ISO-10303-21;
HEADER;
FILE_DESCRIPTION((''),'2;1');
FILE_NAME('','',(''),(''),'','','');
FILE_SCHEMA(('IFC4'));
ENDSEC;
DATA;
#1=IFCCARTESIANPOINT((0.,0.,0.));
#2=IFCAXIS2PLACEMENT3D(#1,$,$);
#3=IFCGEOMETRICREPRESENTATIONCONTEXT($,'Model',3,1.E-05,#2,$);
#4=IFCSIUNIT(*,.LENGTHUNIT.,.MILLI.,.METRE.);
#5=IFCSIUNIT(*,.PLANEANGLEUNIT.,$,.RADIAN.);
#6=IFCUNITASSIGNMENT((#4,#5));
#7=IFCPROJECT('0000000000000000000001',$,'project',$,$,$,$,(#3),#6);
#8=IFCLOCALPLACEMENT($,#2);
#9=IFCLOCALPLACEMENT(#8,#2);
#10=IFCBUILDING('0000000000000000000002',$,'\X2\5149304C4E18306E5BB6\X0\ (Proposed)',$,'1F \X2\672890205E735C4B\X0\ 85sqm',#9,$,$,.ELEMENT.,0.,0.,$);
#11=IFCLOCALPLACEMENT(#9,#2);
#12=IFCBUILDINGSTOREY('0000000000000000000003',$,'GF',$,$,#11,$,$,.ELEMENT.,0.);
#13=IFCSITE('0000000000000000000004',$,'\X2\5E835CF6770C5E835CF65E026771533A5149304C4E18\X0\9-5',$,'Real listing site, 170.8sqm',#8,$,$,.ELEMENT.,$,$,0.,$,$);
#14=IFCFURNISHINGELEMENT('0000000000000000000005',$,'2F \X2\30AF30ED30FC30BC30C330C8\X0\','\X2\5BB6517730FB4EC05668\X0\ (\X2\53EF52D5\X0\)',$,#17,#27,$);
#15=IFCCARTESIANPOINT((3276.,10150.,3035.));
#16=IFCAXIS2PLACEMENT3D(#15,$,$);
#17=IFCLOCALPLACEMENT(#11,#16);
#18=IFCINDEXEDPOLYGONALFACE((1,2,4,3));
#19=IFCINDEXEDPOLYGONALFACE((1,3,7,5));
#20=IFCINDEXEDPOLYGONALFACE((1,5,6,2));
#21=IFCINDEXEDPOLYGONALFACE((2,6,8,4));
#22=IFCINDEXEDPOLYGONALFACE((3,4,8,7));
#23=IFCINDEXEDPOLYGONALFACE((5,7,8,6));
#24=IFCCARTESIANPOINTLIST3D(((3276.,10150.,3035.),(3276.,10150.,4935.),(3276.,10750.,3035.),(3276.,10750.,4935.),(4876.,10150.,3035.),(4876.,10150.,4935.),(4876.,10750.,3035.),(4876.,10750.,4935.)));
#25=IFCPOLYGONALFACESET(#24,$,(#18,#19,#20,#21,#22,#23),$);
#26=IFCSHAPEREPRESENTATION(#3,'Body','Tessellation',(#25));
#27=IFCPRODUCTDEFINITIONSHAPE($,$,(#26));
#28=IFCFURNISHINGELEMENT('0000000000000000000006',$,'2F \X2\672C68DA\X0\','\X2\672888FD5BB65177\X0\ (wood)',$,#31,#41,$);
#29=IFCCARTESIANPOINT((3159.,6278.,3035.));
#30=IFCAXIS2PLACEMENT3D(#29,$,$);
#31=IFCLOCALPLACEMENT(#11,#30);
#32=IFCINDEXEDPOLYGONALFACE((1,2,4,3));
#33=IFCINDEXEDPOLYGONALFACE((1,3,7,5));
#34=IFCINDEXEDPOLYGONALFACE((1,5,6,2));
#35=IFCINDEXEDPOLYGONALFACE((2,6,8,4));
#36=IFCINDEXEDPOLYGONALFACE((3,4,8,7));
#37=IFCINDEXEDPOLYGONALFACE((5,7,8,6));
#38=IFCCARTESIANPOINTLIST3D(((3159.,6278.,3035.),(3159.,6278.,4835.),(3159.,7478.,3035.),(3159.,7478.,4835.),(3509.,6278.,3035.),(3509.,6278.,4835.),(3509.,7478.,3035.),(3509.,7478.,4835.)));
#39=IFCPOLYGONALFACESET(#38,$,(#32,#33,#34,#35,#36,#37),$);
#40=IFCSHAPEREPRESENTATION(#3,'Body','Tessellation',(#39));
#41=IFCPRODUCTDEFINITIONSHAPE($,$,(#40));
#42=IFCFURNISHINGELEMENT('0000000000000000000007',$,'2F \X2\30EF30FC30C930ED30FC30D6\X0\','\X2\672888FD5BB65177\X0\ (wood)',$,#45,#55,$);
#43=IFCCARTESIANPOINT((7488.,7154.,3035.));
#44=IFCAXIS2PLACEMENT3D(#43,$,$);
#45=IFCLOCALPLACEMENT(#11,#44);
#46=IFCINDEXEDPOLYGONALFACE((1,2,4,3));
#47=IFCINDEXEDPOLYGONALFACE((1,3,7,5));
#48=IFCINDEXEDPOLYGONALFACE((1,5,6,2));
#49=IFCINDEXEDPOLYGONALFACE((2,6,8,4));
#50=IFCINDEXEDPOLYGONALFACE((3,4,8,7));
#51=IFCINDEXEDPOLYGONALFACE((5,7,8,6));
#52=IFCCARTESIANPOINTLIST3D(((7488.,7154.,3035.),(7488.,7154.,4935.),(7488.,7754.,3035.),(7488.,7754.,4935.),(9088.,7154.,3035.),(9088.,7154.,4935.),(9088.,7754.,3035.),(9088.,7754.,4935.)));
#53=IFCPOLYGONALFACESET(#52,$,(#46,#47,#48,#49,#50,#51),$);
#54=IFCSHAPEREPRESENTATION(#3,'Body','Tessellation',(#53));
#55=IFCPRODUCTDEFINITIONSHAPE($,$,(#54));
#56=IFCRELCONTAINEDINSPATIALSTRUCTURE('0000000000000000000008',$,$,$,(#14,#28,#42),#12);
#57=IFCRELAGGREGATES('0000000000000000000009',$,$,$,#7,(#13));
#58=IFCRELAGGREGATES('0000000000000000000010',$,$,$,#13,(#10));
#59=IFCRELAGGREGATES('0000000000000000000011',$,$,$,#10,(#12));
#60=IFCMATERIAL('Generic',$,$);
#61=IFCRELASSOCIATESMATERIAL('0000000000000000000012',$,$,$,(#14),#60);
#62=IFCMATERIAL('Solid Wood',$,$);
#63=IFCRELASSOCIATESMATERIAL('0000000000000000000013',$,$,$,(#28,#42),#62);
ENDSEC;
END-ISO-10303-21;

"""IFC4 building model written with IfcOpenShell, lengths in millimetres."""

from ifc_helpers import new_model, si_unit, frame, frame_2d, origin, place, context, project, spatial, rectangle, extrude, material, element, save


model = new_model("IFC4")

# Units and contexts
model_context = context("Model", 3, precision=1e-05, world=origin())
ifc_project = project(units=[si_unit("LENGTHUNIT", "METRE", prefix="MILLI"), si_unit("PLANEANGLEUNIT", "RADIAN")], contexts=[model_context])

# Site, building, storey
site_placement = place(None, origin())
site = spatial("IfcSite", under=ifc_project, at=site_placement, Name="広島県広島市東区光が丘9-5", ObjectType="Real listing site, 170.8sqm", CompositionType="ELEMENT", RefElevation=0.0)
building_placement = place(site_placement, origin())
building = spatial("IfcBuilding", under=site, at=building_placement, Name="光が丘の家 (Proposed)", ObjectType="1F 木造平屋 85sqm", CompositionType="ELEMENT", ElevationOfRefHeight=0.0, ElevationOfTerrain=0.0)
storey_placement = place(building_placement, origin())
storey = spatial("IfcBuildingStorey", under=building, at=storey_placement, Name="GF", CompositionType="ELEMENT", Elevation=0.0)

# Shared definitions
ifc_material_1 = material(Name="Solid Wood")

# Shared definitions
ifc_material_2 = material(Name="Generic")

# Furnishing elements
furnishing_1_placement = place(storey_placement, frame((3276.0, 10150.0, 3035.0)))
element("IfcFurnishingElement", 1, at=furnishing_1_placement, inside=storey, material=ifc_material_2, Name="2F クローゼット", Description="家具・什器 (可動)", context=model_context, shape_type="SweptSolid", body=[
    extrude(rectangle(XDim=1600.0, YDim=600.0, at=frame_2d((800.0, 300.0))), frame((3276.0, 10150.0, 3035.0)), (0.0, 0.0, 1.0), 1900.0),
])
furnishing_2_placement = place(storey_placement, frame((3159.0, 6278.0, 3035.0)))
element("IfcFurnishingElement", 2, at=furnishing_2_placement, inside=storey, material=ifc_material_1, Name="2F 本棚", Description="木製家具 (wood)", context=model_context, shape_type="SweptSolid", body=[
    extrude(rectangle(XDim=350.0, YDim=1200.0, at=frame_2d((175.0, 600.0))), frame((3159.0, 6278.0, 3035.0)), (0.0, 0.0, 1.0), 1800.0),
])
furnishing_3_placement = place(storey_placement, frame((7488.0, 7154.0, 3035.0)))
element("IfcFurnishingElement", 3, at=furnishing_3_placement, inside=storey, material=ifc_material_1, Name="2F ワードローブ", Description="木製家具 (wood)", context=model_context, shape_type="SweptSolid", body=[
    extrude(rectangle(XDim=1600.0, YDim=600.0, at=frame_2d((800.0, 300.0))), frame((7488.0, 7154.0, 3035.0)), (0.0, 0.0, 1.0), 1900.0),
])

save(model, "model.ifc")
